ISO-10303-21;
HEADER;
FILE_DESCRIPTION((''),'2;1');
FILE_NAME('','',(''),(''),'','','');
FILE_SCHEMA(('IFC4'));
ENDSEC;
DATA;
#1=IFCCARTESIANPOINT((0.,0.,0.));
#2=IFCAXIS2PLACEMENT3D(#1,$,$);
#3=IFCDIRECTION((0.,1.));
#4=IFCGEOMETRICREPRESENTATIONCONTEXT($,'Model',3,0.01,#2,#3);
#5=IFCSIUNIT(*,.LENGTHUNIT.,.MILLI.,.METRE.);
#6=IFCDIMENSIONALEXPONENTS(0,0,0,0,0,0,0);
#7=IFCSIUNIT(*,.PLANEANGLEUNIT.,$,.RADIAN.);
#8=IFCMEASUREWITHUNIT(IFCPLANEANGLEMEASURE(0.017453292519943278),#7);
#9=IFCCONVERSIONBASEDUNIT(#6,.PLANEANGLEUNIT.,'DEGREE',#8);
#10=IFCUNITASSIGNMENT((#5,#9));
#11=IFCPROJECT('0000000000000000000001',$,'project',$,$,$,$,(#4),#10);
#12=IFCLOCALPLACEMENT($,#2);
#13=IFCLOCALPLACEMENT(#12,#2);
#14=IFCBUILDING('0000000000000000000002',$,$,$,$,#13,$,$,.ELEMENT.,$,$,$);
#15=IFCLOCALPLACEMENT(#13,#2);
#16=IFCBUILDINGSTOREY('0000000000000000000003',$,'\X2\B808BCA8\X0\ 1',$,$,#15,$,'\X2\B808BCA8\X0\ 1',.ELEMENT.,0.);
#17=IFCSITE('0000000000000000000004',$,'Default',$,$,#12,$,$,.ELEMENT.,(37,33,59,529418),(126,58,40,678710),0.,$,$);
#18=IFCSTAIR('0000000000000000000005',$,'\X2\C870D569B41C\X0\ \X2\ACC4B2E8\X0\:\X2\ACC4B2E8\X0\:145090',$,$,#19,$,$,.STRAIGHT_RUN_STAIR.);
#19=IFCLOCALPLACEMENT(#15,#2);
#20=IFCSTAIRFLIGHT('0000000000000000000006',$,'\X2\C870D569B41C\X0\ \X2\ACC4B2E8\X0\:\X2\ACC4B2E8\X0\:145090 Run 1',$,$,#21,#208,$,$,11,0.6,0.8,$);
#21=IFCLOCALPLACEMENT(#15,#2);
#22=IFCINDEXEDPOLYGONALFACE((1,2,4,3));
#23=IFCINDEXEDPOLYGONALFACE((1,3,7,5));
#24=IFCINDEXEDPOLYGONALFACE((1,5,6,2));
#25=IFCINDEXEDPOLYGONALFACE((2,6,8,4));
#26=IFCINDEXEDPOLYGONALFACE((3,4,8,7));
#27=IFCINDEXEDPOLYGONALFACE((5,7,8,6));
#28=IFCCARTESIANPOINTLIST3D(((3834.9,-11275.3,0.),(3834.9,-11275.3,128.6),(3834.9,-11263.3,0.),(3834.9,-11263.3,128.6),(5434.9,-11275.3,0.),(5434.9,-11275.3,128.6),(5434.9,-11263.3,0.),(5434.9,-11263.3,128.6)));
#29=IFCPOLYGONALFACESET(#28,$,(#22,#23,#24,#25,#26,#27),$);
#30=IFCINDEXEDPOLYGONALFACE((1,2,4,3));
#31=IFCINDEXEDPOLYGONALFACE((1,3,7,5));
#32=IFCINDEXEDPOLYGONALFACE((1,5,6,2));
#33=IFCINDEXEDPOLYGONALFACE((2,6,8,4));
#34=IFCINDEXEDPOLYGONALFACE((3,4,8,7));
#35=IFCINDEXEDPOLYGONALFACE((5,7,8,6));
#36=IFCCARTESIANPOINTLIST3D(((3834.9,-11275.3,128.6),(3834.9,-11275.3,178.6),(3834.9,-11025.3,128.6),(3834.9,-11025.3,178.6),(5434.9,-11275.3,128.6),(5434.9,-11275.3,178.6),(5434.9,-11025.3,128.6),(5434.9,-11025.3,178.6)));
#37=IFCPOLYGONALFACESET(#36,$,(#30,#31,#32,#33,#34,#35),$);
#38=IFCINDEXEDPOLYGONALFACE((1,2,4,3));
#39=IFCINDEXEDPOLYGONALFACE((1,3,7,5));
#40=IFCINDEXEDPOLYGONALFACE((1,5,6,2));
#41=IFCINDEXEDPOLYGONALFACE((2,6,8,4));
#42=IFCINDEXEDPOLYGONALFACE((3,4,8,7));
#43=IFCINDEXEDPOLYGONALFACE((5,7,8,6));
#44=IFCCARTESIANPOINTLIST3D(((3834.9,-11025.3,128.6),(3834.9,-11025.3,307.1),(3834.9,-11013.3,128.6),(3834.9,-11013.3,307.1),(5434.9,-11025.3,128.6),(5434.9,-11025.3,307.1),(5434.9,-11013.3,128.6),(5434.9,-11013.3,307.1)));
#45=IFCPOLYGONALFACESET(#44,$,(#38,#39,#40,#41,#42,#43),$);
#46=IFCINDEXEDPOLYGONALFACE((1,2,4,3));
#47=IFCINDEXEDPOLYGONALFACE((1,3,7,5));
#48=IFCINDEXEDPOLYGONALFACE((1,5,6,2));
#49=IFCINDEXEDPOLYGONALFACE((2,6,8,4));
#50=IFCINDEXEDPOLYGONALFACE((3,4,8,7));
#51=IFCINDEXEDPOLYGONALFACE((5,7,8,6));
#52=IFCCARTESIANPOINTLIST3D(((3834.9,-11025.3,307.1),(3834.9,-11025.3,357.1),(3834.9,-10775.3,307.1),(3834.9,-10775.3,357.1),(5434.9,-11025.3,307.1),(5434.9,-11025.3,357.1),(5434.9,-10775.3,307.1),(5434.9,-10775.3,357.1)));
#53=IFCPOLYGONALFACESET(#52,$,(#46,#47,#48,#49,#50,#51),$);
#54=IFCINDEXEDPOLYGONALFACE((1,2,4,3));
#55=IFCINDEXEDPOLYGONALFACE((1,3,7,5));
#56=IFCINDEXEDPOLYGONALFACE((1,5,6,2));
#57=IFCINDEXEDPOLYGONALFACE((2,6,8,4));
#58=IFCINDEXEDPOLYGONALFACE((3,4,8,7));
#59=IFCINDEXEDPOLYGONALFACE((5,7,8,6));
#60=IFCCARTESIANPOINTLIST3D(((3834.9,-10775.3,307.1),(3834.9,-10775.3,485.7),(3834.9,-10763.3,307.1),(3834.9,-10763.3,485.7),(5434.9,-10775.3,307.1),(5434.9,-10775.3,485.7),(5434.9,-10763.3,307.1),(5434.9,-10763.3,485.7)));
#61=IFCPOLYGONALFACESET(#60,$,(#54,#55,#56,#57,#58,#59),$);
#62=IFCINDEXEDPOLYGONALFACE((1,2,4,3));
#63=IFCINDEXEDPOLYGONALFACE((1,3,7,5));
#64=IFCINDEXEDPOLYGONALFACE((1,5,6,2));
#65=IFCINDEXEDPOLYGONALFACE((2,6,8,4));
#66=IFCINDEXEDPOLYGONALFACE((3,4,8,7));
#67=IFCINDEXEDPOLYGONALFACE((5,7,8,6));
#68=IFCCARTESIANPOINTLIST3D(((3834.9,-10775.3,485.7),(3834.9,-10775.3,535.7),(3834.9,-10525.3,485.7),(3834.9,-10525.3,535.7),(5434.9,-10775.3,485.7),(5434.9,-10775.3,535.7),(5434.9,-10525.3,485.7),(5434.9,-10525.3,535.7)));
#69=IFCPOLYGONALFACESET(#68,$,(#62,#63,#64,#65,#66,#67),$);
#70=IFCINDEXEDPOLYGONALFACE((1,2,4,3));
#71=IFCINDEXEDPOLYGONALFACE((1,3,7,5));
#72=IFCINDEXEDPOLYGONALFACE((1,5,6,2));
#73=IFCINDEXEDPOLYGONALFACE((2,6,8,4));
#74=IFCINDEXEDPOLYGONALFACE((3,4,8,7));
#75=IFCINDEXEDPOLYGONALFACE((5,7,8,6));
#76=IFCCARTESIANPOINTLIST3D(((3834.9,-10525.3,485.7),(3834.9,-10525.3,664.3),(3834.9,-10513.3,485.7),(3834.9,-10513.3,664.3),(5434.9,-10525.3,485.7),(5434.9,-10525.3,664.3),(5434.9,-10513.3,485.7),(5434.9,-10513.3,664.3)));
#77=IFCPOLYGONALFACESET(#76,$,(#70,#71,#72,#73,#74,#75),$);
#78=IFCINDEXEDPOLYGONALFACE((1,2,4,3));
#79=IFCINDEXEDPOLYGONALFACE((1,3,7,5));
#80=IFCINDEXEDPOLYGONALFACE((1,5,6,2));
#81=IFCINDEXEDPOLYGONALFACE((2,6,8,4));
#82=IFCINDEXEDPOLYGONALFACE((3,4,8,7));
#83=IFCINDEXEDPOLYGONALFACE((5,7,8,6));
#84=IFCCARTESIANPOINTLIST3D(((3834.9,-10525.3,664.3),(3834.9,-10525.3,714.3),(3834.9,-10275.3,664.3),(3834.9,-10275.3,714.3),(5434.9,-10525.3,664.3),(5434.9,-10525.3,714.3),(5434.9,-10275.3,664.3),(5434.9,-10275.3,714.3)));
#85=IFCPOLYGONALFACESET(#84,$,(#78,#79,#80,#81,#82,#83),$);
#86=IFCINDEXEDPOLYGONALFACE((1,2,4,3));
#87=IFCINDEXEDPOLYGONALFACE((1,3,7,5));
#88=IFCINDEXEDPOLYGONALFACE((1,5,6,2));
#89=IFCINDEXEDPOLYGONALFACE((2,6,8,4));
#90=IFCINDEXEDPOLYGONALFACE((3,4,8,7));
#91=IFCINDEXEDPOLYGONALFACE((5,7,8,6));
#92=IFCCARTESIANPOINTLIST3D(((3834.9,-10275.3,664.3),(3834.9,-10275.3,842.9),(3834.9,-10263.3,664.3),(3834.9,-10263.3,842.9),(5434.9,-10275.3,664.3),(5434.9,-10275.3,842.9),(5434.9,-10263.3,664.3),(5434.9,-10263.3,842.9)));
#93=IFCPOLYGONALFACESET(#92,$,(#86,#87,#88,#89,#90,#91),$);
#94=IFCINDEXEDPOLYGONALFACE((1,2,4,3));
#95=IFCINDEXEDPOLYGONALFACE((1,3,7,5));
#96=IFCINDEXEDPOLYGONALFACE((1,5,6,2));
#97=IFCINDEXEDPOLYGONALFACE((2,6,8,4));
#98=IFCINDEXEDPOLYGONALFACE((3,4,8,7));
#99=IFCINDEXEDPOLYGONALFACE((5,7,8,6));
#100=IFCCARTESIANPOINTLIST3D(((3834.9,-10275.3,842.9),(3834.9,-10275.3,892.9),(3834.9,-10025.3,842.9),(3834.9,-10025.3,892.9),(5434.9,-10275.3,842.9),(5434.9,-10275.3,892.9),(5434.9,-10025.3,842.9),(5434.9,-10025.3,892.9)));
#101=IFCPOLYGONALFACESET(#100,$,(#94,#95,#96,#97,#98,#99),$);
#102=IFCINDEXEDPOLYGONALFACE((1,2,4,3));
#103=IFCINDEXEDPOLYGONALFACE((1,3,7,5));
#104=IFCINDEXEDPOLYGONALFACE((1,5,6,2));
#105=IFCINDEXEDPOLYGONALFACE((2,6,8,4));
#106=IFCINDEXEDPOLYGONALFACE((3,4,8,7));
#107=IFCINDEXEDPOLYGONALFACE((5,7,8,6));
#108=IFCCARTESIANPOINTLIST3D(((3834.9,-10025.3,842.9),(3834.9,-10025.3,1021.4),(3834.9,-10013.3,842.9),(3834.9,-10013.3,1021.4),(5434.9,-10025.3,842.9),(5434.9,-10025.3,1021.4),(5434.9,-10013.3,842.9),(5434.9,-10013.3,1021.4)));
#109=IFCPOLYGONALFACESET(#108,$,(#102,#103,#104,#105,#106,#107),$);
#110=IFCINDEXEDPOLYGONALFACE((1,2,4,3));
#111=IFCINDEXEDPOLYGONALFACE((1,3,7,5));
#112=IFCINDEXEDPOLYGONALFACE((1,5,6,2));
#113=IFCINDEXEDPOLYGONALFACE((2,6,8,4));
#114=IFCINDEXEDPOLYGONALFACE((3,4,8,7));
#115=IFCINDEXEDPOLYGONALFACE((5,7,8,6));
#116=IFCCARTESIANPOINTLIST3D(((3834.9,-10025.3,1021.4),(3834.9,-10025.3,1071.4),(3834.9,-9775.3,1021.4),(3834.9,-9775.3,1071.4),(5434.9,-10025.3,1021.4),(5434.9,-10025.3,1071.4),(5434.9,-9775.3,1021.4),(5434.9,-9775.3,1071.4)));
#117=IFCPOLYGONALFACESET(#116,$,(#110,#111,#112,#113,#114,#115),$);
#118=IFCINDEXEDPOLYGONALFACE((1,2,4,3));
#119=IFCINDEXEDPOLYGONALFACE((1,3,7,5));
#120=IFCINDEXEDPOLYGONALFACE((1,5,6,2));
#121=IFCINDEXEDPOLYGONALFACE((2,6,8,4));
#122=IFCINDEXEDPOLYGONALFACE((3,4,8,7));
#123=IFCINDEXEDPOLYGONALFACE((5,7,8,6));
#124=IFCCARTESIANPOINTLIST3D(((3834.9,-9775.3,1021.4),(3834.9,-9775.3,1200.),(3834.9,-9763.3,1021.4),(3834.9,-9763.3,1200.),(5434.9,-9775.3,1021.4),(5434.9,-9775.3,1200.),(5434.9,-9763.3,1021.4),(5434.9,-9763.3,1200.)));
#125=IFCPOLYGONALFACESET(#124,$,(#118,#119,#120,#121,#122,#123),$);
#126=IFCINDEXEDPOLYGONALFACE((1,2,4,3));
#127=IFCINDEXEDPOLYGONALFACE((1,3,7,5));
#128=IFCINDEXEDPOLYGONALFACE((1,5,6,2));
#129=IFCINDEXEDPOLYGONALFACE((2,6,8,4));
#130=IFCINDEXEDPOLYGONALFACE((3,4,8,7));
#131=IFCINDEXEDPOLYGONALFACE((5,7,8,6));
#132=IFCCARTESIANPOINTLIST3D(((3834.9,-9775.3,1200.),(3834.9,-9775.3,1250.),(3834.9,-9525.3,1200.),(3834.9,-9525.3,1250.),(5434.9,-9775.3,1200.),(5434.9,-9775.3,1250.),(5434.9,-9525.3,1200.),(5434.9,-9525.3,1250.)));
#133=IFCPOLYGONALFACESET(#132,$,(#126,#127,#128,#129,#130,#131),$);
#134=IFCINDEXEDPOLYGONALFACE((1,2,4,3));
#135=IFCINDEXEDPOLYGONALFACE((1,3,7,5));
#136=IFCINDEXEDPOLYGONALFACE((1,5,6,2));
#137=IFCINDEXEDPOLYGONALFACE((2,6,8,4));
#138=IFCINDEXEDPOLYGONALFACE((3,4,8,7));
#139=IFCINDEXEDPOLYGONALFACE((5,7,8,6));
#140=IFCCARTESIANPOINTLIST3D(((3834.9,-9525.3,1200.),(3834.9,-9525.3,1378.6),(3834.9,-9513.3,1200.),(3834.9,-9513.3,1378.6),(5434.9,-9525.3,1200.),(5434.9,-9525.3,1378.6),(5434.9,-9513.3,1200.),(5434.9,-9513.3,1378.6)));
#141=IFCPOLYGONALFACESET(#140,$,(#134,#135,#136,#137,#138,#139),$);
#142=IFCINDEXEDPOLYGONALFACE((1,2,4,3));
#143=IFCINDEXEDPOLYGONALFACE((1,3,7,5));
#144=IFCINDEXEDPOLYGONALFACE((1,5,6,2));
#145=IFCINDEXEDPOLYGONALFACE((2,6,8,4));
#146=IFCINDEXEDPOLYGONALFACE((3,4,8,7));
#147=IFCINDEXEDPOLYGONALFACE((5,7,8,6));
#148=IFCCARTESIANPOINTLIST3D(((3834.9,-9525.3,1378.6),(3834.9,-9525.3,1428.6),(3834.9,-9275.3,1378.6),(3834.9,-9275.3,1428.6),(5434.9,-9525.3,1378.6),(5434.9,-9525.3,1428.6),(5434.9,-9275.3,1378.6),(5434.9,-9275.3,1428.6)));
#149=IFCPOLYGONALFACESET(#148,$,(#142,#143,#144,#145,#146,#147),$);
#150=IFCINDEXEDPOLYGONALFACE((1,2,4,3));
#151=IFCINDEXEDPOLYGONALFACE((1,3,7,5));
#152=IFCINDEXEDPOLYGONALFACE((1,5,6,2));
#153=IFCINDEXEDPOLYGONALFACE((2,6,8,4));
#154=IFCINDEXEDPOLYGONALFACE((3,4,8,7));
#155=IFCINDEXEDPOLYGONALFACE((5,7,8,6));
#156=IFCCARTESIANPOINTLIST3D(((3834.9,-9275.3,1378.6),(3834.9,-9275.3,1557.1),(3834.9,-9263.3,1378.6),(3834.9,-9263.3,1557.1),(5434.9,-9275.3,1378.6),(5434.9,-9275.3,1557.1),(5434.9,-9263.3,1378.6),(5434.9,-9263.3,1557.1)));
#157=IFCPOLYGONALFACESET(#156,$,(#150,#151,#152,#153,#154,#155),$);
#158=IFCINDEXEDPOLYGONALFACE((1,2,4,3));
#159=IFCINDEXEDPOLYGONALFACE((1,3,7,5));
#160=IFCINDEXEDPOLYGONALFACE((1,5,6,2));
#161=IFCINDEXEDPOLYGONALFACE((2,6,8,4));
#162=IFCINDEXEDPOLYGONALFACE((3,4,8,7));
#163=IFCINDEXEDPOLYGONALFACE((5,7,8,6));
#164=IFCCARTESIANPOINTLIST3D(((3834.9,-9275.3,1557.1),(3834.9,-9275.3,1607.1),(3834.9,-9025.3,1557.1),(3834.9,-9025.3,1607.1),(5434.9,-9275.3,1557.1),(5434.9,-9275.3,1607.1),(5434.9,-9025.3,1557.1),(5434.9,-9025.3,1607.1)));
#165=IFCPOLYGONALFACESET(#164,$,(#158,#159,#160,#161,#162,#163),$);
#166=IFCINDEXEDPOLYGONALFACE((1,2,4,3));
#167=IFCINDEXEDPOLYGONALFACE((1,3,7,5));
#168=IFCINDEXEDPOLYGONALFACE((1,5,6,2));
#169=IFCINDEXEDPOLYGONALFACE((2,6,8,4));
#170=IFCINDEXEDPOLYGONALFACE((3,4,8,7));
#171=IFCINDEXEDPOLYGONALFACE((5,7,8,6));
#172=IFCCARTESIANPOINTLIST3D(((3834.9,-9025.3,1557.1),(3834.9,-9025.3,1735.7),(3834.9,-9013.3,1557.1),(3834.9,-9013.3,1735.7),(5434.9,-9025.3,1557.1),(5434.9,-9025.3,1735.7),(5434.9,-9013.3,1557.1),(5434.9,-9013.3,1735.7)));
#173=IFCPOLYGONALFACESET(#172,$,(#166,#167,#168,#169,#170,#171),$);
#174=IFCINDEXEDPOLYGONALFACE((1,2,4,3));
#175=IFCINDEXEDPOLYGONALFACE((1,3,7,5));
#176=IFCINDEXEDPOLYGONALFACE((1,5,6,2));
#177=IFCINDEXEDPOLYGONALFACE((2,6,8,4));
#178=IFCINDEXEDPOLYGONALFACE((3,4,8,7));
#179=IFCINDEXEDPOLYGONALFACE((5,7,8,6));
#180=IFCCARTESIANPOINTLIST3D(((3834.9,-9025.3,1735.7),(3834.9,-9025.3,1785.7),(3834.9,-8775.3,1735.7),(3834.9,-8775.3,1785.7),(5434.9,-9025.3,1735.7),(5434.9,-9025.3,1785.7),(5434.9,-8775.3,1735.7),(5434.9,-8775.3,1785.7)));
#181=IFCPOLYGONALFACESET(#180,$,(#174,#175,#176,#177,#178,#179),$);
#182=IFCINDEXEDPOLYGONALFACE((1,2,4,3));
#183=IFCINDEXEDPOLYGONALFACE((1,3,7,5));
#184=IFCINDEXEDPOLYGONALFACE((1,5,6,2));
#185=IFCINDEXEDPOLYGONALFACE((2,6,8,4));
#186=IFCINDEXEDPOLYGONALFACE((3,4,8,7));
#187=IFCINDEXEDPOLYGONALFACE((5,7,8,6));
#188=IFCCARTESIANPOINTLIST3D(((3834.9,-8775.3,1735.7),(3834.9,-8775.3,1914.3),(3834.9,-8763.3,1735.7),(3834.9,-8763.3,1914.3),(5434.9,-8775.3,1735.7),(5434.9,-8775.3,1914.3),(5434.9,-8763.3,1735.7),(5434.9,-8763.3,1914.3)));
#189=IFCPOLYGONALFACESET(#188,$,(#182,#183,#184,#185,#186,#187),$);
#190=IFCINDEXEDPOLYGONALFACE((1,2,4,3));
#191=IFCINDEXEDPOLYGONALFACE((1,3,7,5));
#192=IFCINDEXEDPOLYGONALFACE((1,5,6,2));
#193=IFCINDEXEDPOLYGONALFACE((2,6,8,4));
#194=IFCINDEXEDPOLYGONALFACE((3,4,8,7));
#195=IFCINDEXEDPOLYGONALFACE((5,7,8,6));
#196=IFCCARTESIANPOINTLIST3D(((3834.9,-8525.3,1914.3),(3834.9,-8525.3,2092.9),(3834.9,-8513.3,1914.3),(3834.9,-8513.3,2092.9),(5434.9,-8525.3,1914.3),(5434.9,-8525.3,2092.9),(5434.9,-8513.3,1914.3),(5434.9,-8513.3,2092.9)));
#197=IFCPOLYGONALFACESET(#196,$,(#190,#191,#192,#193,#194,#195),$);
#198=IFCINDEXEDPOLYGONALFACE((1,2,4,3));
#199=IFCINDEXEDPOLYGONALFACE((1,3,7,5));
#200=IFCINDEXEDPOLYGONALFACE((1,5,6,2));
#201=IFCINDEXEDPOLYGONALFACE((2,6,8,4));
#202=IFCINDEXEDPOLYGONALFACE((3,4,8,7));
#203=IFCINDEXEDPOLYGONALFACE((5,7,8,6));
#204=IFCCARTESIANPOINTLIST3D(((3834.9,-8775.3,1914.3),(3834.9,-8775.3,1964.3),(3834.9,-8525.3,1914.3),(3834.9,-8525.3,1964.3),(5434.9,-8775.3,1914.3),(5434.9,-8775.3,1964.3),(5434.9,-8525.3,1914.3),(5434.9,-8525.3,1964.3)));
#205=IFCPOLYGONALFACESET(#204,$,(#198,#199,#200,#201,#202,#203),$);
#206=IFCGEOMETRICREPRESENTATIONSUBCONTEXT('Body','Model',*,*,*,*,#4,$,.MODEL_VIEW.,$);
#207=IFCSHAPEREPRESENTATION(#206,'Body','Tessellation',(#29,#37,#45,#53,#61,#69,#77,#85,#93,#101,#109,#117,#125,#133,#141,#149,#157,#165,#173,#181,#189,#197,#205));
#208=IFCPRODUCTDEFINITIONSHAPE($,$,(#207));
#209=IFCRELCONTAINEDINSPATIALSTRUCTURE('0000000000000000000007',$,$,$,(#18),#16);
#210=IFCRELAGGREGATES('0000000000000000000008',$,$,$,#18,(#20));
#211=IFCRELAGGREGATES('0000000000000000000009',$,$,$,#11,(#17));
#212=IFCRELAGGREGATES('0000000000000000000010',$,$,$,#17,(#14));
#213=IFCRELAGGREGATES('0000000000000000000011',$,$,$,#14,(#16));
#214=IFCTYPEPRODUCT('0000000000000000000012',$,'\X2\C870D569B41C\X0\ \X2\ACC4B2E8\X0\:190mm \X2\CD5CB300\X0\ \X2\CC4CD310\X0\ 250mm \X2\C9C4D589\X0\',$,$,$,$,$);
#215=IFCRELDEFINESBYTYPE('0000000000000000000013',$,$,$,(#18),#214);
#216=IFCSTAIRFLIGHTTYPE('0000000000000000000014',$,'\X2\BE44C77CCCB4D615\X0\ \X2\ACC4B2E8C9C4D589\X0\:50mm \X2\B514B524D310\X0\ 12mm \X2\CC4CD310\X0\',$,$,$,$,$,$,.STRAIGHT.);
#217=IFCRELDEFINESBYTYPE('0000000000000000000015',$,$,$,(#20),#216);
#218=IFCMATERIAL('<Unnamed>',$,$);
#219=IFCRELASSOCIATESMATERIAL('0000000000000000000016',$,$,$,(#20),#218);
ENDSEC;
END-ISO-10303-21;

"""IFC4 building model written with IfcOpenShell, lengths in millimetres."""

from ifc_helpers import new_model, entity, si_unit, converted_unit, direction, frame, frame_2d, origin, origin_2d_with_axis, place, context, subcontext, project, spatial, rectangle, extrude, material, type_object, element, aggregate, save


model = new_model("IFC4")

# Units and contexts
model_context = context("Model", 3, precision=0.01, world=origin(), true_north=direction((0.0, 1.0)))
body_context = subcontext(model_context, "Body", "Model", "MODEL_VIEW")
ifc_project = project(units=[si_unit("LENGTHUNIT", "METRE", prefix="MILLI"), converted_unit("PLANEANGLEUNIT", "DEGREE", entity("IfcPlaneAngleMeasure", 0.017453292519943278), si_unit("PLANEANGLEUNIT", "RADIAN"), dimensions=[0, 0, 0, 0, 0, 0, 0])], contexts=[model_context])

# Site, building, storey
site_placement = place(None, origin())
site = spatial("IfcSite", under=ifc_project, at=site_placement, Name="Default", CompositionType="ELEMENT", RefLatitude=(37, 33, 59, 529418), RefLongitude=(126, 58, 40, 678710), RefElevation=0.0)
building_placement = place(site_placement, origin())
building = spatial("IfcBuilding", under=site, at=building_placement, CompositionType="ELEMENT")
storey_placement = place(building_placement, origin())
storey = spatial("IfcBuildingStorey", under=building, at=storey_placement, Name="레벨 1", LongName="레벨 1", CompositionType="ELEMENT", Elevation=0.0)

# Stair
type_product = type_object("IfcTypeProduct", Name="조합된 계단:190mm 최대 챌판 250mm 진행")
stair_placement = place(storey_placement, origin())
stair = element("IfcStair", 1, at=stair_placement, inside=storey, type_object=type_product, Name="조합된 계단:계단:145090", PredefinedType="STRAIGHT_RUN_STAIR")
ifc_material_1 = material(Name="<Unnamed>")

# Stair flight
stair_flight_type = type_object("IfcStairFlightType", Name="비일체형 계단진행:50mm 디딤판 12mm 챌판", PredefinedType="STRAIGHT")
stair_flight_placement = place(stair_placement, origin())
stair_flight = element("IfcStairFlight", 2, at=stair_flight_placement, type_object=stair_flight_type, material=ifc_material_1, Name="조합된 계단:계단:145090 Run 1", NumberOfTreads=11, RiserHeight=0.6, TreadLength=0.8, context=body_context, shape_type="SweptSolid", body=[
    extrude(rectangle(XDim=1600.0, YDim=12.0, at=frame_2d((0.0, 0.0), x_axis=(1.0, 0.0))), frame((4634.9, -11269.3, 0.0), z_axis=(0.0, 0.0, 1.0), x_axis=(-1.0, 0.0, 0.0)), (0.0, 0.0, 1.0), 128.6),
    extrude(rectangle(XDim=250.0, YDim=1600.0, at=frame_2d((0.0, 0.0), x_axis=(1.0, 0.0))), frame((4634.9, -11150.3, 128.6), z_axis=(0.0, 0.0, 1.0), x_axis=(0.0, -1.0, 0.0)), (0.0, 0.0, 1.0), 50.0),
    extrude(rectangle(XDim=1600.0, YDim=12.0, at=frame_2d((0.0, 0.0), x_axis=(1.0, 0.0))), frame((4634.9, -11019.3, 128.6), z_axis=(0.0, 0.0, 1.0), x_axis=(-1.0, 0.0, 0.0)), (0.0, 0.0, 1.0), 178.6),
    extrude(rectangle(XDim=250.0, YDim=1600.0, at=frame_2d((0.0, 0.0), x_axis=(1.0, 0.0))), frame((4634.9, -10900.3, 307.1), z_axis=(0.0, 0.0, 1.0), x_axis=(0.0, -1.0, 0.0)), (0.0, 0.0, 1.0), 50.0),
    extrude(rectangle(XDim=1600.0, YDim=12.0, at=frame_2d((0.0, 0.0), x_axis=(1.0, 0.0))), frame((4634.9, -10769.3, 307.1), z_axis=(0.0, 0.0, 1.0), x_axis=(-1.0, 0.0, 0.0)), (0.0, 0.0, 1.0), 178.6),
    extrude(rectangle(XDim=250.0, YDim=1600.0, at=origin_2d_with_axis()), frame((4634.9, -10650.3, 485.7), z_axis=(0.0, 0.0, 1.0), x_axis=(0.0, -1.0, 0.0)), (0.0, 0.0, 1.0), 50.0),
    extrude(rectangle(XDim=1600.0, YDim=12.0, at=frame_2d((0.0, 0.0), x_axis=(1.0, 0.0))), frame((4634.9, -10519.3, 485.7), z_axis=(0.0, 0.0, 1.0), x_axis=(-1.0, 0.0, 0.0)), (0.0, 0.0, 1.0), 178.6),
    extrude(rectangle(XDim=250.0, YDim=1600.0, at=frame_2d((0.0, 0.0), x_axis=(1.0, 0.0))), frame((4634.9, -10400.3, 664.3), z_axis=(0.0, 0.0, 1.0), x_axis=(0.0, -1.0, 0.0)), (0.0, 0.0, 1.0), 50.0),
    extrude(rectangle(XDim=1600.0, YDim=12.0, at=frame_2d((0.0, 0.0), x_axis=(1.0, 0.0))), frame((4634.9, -10269.3, 664.3), z_axis=(0.0, 0.0, 1.0), x_axis=(-1.0, 0.0, 0.0)), (0.0, 0.0, 1.0), 178.6),
    extrude(rectangle(XDim=250.0, YDim=1600.0, at=origin_2d_with_axis()), frame((4634.9, -10150.3, 842.9), z_axis=(0.0, 0.0, 1.0), x_axis=(0.0, -1.0, 0.0)), (0.0, 0.0, 1.0), 50.0),
    extrude(rectangle(XDim=1600.0, YDim=12.0, at=frame_2d((0.0, 0.0), x_axis=(1.0, 0.0))), frame((4634.9, -10019.3, 842.9), z_axis=(0.0, 0.0, 1.0), x_axis=(-1.0, 0.0, 0.0)), (0.0, 0.0, 1.0), 178.6),
    extrude(rectangle(XDim=250.0, YDim=1600.0, at=origin_2d_with_axis()), frame((4634.9, -9900.3, 1021.4), z_axis=(0.0, 0.0, 1.0), x_axis=(0.0, -1.0, 0.0)), (0.0, 0.0, 1.0), 50.0),
    extrude(rectangle(XDim=1600.0, YDim=12.0, at=frame_2d((0.0, 0.0), x_axis=(1.0, 0.0))), frame((4634.9, -9769.3, 1021.4), z_axis=(0.0, 0.0, 1.0), x_axis=(-1.0, 0.0, 0.0)), (0.0, 0.0, 1.0), 178.6),
    extrude(rectangle(XDim=250.0, YDim=1600.0, at=frame_2d((0.0, 0.0), x_axis=(1.0, 0.0))), frame((4634.9, -9650.3, 1200.0), z_axis=(0.0, 0.0, 1.0), x_axis=(0.0, -1.0, 0.0)), (0.0, 0.0, 1.0), 50.0),
    extrude(rectangle(XDim=1600.0, YDim=12.0, at=frame_2d((0.0, 0.0), x_axis=(1.0, 0.0))), frame((4634.9, -9519.3, 1200.0), z_axis=(0.0, 0.0, 1.0), x_axis=(-1.0, 0.0, 0.0)), (0.0, 0.0, 1.0), 178.6),
    extrude(rectangle(XDim=250.0, YDim=1600.0, at=origin_2d_with_axis()), frame((4634.9, -9400.3, 1378.6), z_axis=(0.0, 0.0, 1.0), x_axis=(0.0, -1.0, 0.0)), (0.0, 0.0, 1.0), 50.0),
    extrude(rectangle(XDim=1600.0, YDim=12.0, at=frame_2d((0.0, 0.0), x_axis=(1.0, 0.0))), frame((4634.9, -9269.3, 1378.6), z_axis=(0.0, 0.0, 1.0), x_axis=(-1.0, 0.0, 0.0)), (0.0, 0.0, 1.0), 178.6),
    extrude(rectangle(XDim=250.0, YDim=1600.0, at=frame_2d((0.0, 0.0), x_axis=(1.0, 0.0))), frame((4634.9, -9150.3, 1557.1), z_axis=(0.0, 0.0, 1.0), x_axis=(0.0, -1.0, 0.0)), (0.0, 0.0, 1.0), 50.0),
    extrude(rectangle(XDim=1600.0, YDim=12.0, at=frame_2d((0.0, 0.0), x_axis=(1.0, 0.0))), frame((4634.9, -9019.3, 1557.1), z_axis=(0.0, 0.0, 1.0), x_axis=(-1.0, 0.0, 0.0)), (0.0, 0.0, 1.0), 178.6),
    extrude(rectangle(XDim=250.0, YDim=1600.0, at=frame_2d((0.0, 0.0), x_axis=(1.0, 0.0))), frame((4634.9, -8900.3, 1735.7), z_axis=(0.0, 0.0, 1.0), x_axis=(0.0, -1.0, 0.0)), (0.0, 0.0, 1.0), 50.0),
    extrude(rectangle(XDim=1600.0, YDim=12.0, at=frame_2d((0.0, 0.0), x_axis=(1.0, 0.0))), frame((4634.9, -8769.3, 1735.7), z_axis=(0.0, 0.0, 1.0), x_axis=(-1.0, 0.0, 0.0)), (0.0, 0.0, 1.0), 178.6),
    extrude(rectangle(XDim=1600.0, YDim=12.0, at=frame_2d((0.0, 0.0), x_axis=(1.0, 0.0))), frame((4634.9, -8519.3, 1914.3), z_axis=(0.0, 0.0, 1.0), x_axis=(-1.0, 0.0, 0.0)), (0.0, 0.0, 1.0), 178.6),
    extrude(rectangle(XDim=250.0, YDim=1600.0, at=origin_2d_with_axis()), frame((4634.9, -8650.3, 1914.3), z_axis=(0.0, 0.0, 1.0), x_axis=(0.0, -1.0, 0.0)), (0.0, 0.0, 1.0), 50.0),
])
aggregate(stair, [stair_flight])

save(model, "model.ifc")
